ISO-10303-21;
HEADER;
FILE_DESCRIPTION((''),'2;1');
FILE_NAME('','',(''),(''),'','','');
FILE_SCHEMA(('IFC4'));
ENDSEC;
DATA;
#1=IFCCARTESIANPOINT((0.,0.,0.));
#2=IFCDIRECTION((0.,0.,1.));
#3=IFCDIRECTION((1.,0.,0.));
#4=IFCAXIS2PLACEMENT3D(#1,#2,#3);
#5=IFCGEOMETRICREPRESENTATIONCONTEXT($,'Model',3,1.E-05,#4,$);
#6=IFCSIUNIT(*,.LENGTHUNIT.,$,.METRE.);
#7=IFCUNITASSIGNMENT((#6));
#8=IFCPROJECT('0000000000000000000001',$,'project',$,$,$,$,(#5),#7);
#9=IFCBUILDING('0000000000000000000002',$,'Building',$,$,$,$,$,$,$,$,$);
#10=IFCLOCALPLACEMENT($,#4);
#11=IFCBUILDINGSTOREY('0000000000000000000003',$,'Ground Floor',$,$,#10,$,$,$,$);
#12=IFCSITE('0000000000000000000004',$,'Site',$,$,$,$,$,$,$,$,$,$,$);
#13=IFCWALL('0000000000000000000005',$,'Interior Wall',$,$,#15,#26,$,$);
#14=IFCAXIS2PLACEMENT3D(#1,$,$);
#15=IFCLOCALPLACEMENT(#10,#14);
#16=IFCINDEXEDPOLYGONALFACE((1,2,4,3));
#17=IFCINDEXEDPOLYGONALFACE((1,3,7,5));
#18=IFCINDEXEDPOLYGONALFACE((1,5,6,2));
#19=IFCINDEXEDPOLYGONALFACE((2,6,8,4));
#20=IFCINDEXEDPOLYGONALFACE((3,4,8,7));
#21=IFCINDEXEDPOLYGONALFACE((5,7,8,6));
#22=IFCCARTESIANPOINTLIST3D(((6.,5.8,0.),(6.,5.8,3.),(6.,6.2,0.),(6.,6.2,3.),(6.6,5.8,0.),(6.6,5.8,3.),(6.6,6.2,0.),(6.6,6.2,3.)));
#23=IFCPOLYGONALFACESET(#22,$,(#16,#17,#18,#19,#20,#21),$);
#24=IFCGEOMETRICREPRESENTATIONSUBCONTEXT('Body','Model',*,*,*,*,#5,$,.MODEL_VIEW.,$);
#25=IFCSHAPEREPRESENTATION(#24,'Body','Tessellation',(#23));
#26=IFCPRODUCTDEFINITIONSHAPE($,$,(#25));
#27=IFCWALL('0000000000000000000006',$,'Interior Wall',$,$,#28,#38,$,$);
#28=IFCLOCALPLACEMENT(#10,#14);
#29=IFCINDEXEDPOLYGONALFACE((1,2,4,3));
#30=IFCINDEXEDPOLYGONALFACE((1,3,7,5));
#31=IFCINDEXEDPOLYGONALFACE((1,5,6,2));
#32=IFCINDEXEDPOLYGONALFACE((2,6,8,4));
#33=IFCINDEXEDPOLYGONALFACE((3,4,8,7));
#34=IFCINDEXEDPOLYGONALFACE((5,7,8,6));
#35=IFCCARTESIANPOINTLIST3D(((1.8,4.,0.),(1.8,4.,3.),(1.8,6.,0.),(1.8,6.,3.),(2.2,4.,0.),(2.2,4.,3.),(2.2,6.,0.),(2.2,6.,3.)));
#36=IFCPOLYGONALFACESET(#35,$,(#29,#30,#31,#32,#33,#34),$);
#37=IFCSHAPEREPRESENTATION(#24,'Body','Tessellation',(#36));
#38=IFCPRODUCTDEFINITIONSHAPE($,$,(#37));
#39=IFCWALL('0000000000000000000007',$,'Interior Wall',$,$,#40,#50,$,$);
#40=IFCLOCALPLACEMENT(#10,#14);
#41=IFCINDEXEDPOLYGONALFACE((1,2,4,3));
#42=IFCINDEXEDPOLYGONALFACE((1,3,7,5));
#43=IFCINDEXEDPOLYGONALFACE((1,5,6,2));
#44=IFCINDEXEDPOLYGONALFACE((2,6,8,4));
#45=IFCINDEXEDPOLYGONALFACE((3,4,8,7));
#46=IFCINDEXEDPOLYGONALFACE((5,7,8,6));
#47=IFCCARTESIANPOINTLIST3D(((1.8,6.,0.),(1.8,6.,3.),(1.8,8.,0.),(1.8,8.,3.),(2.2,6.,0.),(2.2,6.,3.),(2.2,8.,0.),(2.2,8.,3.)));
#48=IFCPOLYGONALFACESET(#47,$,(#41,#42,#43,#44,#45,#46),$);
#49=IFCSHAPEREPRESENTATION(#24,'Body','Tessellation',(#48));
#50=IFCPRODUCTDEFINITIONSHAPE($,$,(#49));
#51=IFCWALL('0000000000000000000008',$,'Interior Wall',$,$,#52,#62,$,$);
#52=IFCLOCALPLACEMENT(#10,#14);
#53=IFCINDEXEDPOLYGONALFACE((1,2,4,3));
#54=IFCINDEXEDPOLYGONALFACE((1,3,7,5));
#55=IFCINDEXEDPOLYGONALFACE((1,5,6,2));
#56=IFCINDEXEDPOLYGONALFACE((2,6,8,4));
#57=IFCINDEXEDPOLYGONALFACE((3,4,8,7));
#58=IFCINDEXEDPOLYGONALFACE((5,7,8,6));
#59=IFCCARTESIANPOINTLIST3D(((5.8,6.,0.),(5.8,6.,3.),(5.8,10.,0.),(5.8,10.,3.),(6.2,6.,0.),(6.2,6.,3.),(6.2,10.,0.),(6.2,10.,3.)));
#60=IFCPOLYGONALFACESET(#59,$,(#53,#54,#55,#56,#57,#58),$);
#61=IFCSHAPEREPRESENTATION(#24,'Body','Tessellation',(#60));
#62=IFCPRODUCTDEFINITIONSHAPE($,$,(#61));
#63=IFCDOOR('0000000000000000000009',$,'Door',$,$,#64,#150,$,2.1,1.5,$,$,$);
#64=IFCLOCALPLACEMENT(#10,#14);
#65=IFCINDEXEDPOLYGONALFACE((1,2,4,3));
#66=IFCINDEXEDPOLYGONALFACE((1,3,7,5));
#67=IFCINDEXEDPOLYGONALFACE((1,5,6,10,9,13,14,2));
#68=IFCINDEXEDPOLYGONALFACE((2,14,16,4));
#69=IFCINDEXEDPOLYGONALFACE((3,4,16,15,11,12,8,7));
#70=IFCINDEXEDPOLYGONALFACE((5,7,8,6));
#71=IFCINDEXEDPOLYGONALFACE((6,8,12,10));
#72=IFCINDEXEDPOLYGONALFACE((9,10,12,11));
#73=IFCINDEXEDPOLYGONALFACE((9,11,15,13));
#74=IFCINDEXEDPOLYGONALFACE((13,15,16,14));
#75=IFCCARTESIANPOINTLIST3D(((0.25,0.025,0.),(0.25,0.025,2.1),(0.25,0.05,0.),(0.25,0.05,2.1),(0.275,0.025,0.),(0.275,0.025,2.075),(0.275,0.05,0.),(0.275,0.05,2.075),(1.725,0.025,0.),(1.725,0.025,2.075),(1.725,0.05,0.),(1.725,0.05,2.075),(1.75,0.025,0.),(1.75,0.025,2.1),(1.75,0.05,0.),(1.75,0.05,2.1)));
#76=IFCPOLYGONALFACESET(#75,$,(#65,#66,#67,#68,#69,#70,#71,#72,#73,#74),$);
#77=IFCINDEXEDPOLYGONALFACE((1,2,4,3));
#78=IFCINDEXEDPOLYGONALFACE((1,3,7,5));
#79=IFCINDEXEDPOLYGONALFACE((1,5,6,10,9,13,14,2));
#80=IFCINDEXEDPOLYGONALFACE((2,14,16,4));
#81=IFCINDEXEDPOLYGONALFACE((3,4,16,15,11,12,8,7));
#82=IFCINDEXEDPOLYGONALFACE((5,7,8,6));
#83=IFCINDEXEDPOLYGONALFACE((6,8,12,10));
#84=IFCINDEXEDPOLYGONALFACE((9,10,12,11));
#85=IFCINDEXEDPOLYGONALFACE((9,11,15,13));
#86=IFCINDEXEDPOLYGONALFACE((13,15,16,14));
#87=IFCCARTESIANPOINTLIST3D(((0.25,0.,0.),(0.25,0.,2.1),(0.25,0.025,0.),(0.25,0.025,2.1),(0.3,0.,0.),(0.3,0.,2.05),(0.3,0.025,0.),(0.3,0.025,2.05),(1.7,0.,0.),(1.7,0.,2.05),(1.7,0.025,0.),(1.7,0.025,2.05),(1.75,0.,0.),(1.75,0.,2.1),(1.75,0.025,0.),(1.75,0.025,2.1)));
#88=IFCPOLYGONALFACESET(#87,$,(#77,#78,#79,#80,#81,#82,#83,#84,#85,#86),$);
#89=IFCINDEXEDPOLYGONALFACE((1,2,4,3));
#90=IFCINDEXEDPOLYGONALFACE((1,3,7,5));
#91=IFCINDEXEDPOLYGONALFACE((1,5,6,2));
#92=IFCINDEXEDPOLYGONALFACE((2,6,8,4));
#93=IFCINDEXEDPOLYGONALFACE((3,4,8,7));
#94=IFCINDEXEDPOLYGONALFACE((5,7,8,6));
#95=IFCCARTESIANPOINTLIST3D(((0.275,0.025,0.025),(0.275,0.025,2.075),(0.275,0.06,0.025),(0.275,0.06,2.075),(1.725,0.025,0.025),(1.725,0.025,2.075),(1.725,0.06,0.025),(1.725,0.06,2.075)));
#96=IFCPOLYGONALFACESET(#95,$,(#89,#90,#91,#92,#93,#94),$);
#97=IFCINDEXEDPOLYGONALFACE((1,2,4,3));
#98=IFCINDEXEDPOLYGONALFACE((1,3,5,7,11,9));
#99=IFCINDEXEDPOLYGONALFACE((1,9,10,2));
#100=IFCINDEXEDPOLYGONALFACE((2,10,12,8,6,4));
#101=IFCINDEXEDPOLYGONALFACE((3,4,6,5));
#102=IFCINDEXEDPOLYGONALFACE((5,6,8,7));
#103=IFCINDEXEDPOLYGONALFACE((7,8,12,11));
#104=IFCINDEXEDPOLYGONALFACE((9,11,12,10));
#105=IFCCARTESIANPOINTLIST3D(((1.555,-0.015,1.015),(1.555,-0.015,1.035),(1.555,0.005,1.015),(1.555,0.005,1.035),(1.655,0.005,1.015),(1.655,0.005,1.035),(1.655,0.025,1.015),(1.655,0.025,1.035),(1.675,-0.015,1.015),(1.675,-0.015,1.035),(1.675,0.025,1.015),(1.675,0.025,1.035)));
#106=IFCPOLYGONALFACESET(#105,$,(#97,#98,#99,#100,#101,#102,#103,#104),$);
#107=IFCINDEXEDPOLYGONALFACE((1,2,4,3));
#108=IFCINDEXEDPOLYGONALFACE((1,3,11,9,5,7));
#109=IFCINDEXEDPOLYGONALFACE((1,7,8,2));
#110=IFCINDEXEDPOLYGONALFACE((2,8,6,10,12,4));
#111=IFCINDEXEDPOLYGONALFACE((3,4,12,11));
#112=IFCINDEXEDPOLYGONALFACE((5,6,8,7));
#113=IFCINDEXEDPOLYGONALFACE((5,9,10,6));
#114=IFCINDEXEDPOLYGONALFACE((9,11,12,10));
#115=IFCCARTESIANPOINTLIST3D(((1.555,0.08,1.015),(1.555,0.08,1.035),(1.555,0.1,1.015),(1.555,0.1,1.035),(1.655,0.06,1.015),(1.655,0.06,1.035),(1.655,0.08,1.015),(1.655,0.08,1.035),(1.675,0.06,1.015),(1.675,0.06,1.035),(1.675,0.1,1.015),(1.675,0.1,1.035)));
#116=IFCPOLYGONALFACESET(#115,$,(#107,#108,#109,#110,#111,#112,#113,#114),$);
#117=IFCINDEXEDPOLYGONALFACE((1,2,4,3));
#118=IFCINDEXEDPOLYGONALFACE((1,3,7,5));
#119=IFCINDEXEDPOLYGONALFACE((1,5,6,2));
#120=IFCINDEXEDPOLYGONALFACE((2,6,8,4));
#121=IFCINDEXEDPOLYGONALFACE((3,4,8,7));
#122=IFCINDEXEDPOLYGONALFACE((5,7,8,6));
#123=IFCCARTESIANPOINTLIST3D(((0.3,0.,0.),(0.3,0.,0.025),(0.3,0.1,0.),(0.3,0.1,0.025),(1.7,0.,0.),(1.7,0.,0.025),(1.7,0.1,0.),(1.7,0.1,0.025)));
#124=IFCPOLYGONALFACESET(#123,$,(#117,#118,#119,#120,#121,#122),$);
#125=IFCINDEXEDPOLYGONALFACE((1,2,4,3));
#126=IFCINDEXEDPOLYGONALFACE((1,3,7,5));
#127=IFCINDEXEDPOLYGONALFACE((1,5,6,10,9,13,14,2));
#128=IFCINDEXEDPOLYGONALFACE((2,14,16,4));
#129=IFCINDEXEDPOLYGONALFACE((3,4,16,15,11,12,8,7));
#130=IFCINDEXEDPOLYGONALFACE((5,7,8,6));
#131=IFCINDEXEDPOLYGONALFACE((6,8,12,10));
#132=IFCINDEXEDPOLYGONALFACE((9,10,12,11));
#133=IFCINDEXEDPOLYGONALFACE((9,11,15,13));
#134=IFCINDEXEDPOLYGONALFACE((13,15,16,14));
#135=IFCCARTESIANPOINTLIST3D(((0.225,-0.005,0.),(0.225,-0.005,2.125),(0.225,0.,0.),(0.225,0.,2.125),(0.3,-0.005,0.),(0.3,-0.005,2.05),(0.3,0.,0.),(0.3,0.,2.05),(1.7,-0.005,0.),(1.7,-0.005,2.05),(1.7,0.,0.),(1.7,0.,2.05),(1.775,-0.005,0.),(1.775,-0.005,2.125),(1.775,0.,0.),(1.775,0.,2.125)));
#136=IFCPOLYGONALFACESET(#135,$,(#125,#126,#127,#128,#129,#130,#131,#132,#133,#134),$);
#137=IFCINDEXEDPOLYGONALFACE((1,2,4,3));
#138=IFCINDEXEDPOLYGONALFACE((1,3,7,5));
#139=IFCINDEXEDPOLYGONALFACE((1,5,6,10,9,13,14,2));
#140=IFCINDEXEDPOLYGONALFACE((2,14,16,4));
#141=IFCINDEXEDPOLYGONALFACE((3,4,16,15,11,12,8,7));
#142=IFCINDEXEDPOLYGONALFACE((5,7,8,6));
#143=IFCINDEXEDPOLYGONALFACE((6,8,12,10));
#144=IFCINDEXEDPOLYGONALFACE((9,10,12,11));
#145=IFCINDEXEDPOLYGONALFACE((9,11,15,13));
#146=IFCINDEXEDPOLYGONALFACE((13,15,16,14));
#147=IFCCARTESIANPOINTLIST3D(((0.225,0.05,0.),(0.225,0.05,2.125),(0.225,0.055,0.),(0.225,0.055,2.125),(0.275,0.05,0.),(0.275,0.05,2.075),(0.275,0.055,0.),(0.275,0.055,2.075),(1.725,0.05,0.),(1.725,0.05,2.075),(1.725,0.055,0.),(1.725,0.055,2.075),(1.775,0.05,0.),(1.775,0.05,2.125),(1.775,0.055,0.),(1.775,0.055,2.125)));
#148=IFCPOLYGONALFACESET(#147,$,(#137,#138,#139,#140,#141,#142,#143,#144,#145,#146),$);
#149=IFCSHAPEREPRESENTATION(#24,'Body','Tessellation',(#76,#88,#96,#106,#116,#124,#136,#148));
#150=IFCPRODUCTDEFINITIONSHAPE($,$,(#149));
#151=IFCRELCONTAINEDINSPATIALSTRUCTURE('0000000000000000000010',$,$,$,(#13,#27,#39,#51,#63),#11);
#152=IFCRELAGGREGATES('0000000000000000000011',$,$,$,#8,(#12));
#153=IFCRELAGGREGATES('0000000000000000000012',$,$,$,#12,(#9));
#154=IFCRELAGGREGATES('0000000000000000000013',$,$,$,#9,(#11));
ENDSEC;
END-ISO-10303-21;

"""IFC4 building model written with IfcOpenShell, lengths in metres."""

from ifc_helpers import new_model, si_unit, frame, origin_with_axes, place, context, subcontext, project, spatial, line, indexed_curve, outline, extrude, element, save


model = new_model("IFC4")

# Units and contexts
model_context = context("Model", 3, precision=1e-05, world=origin_with_axes())
body_context = subcontext(model_context, "Body", "Model", "MODEL_VIEW")
ifc_project = project(units=[si_unit("LENGTHUNIT", "METRE")], contexts=[model_context])

# Site, building, storey
site = spatial("IfcSite", under=ifc_project, Name="Site")
building = spatial("IfcBuilding", under=site, Name="Building")
storey_placement = place(None, origin_with_axes())
storey = spatial("IfcBuildingStorey", under=building, at=storey_placement, Name="Ground Floor")

# Walls
wall_1_placement = place(storey_placement, frame((6.6, 6.0, 0.0), z_axis=(0.0, 0.0, 1.0), x_axis=(-1.0, 0.0, 0.0)))
element("IfcWall", 1, at=wall_1_placement, inside=storey, Name="Interior Wall", context=body_context, shape_type="SweptSolid", body=[
    extrude(outline(indexed_curve([(0.0, 0.0), (0.0, 0.4), (0.6, 0.4), (0.6, 0.0), (0.0, 0.0)], self_intersect=False)), frame((0.0, -0.2, 0.0), z_axis=(0.0, 0.0, 1.0), x_axis=(1.0, 0.0, 0.0)), (0.0, 0.0, 1.0), 3.0),
])
for number, where, z_axis, x_axis, name in (
    (2, (2.0, 6.0, 0.0), (0.0, 0.0, 1.0), (0.0, -1.0, 0.0), "Interior Wall"),
    (3, (2.0, 6.0, 0.0), (0.0, 0.0, 1.0), (0.0, 1.0, 0.0), "Interior Wall"),
):
    element("IfcWall", number, at=place(storey_placement, frame(where, z_axis=z_axis, x_axis=x_axis)), inside=storey, Name=name, context=body_context, shape_type="SweptSolid", body=[
        extrude(outline(indexed_curve([(0.0, 0.0), (0.0, 0.4), (2.0, 0.4), (2.0, 0.0), (0.0, 0.0)], self_intersect=False)), frame((0.0, -0.2, 0.0), z_axis=(0.0, 0.0, 1.0), x_axis=(1.0, 0.0, 0.0)), (0.0, 0.0, 1.0), 3.0),
    ])
wall_2_placement = place(storey_placement, frame((6.0, 6.0, 0.0), z_axis=(0.0, 0.0, 1.0), x_axis=(0.0, 1.0, 0.0)))
element("IfcWall", 4, at=wall_2_placement, inside=storey, Name="Interior Wall", context=body_context, shape_type="SweptSolid", body=[
    extrude(outline(indexed_curve([(0.0, 0.0), (0.0, 0.4), (4.0, 0.4), (4.0, 0.0), (0.0, 0.0)], self_intersect=False)), frame((0.0, -0.2, 0.0), z_axis=(0.0, 0.0, 1.0), x_axis=(1.0, 0.0, 0.0)), (0.0, 0.0, 1.0), 3.0),
])

# Door
door_1_placement = place(storey_placement, frame((0.25, 0.0, 0.0), z_axis=(0.0, 0.0, 1.0), x_axis=(1.0, 0.0, 0.0)))
element("IfcDoor", 5, at=door_1_placement, inside=storey, Name="Door", OverallHeight=2.1, OverallWidth=1.5, context=body_context, shape_type="SweptSolid", body=[
    extrude(outline(indexed_curve([(0.0, 0.0), (0.0, 2.1), (1.5, 2.1), (1.5, 0.0), (1.475, 0.0), (1.475, 2.075), (0.025, 2.075), (0.025, 0.0)], segments=[line(1, 2, 3, 4, 5, 6, 7, 8, 1)])), frame((0.0, 0.025, 0.0), z_axis=(0.0, -1.0, 0.0), x_axis=(1.0, 0.0, 0.0)), (0.0, 0.0, -1.0), 0.025),
    extrude(outline(indexed_curve([(0.0, 0.0), (0.0, 2.1), (1.5, 2.1), (1.5, 0.0), (1.45, 0.0), (1.45, 2.05), (0.05, 2.05), (0.05, 0.0)], segments=[line(1, 2, 3, 4, 5, 6, 7, 8, 1)])), frame((0.0, 0.0, 0.0), z_axis=(0.0, -1.0, 0.0), x_axis=(1.0, 0.0, 0.0)), (0.0, 0.0, -1.0), 0.025),
    extrude(outline(indexed_curve([(0.0, 0.0), (1.45, 0.0), (1.45, 0.035), (0.0, 0.035)], segments=[line(1, 2, 3, 4, 1)])), frame((0.025, 0.025, 0.025), z_axis=(0.0, 0.0, 1.0), x_axis=(1.0, 0.0, 0.0)), (0.0, 0.0, 1.0), 2.05),
    extrude(outline(indexed_curve([(0.0, 0.0), (0.0, -0.04), (-0.12, -0.04), (-0.12, -0.02), (-0.02, -0.02), (-0.02, 0.0)], segments=[line(1, 2, 3, 4, 5, 6, 1)])), frame((1.425, 0.025, 1.015), z_axis=(0.0, 0.0, 1.0), x_axis=(1.0, 0.0, 0.0)), (0.0, 0.0, 1.0), 0.02),
    extrude(outline(indexed_curve([(0.0, 0.0), (0.0, 0.04), (-0.12, 0.04), (-0.12, 0.02), (-0.02, 0.02), (-0.02, 0.0)], segments=[line(1, 2, 3, 4, 5, 6, 1)])), frame((1.425, 0.06, 1.015), z_axis=(0.0, 0.0, 1.0), x_axis=(1.0, 0.0, 0.0)), (0.0, 0.0, 1.0), 0.02),
    extrude(outline(indexed_curve([(0.0, 0.0), (1.4, 0.0), (1.4, 0.1), (0.0, 0.1)], segments=[line(1, 2, 3, 4, 1)])), frame((0.05, 0.0, 0.0), z_axis=(0.0, 0.0, 1.0), x_axis=(1.0, 0.0, 0.0)), (0.0, 0.0, 1.0), 0.025),
    extrude(outline(indexed_curve([(0.0, 0.0), (0.0, 2.125), (1.55, 2.125), (1.55, 0.0), (1.475, 0.0), (1.475, 2.05), (0.075, 2.05), (0.075, 0.0)], segments=[line(1, 2, 3, 4, 5, 6, 7, 8, 1)])), frame((-0.025, -0.005, 0.0), z_axis=(0.0, -1.0, 0.0), x_axis=(1.0, 0.0, 0.0)), (0.0, 0.0, -1.0), 0.005),
    extrude(outline(indexed_curve([(0.0, 0.0), (0.0, 2.125), (1.55, 2.125), (1.55, 0.0), (1.5, 0.0), (1.5, 2.075), (0.05, 2.075), (0.05, 0.0)], segments=[line(1, 2, 3, 4, 5, 6, 7, 8, 1)])), frame((-0.025, 0.05, 0.0), z_axis=(0.0, -1.0, 0.0), x_axis=(1.0, 0.0, 0.0)), (0.0, 0.0, -1.0), 0.005),
])

save(model, "model.ifc")
